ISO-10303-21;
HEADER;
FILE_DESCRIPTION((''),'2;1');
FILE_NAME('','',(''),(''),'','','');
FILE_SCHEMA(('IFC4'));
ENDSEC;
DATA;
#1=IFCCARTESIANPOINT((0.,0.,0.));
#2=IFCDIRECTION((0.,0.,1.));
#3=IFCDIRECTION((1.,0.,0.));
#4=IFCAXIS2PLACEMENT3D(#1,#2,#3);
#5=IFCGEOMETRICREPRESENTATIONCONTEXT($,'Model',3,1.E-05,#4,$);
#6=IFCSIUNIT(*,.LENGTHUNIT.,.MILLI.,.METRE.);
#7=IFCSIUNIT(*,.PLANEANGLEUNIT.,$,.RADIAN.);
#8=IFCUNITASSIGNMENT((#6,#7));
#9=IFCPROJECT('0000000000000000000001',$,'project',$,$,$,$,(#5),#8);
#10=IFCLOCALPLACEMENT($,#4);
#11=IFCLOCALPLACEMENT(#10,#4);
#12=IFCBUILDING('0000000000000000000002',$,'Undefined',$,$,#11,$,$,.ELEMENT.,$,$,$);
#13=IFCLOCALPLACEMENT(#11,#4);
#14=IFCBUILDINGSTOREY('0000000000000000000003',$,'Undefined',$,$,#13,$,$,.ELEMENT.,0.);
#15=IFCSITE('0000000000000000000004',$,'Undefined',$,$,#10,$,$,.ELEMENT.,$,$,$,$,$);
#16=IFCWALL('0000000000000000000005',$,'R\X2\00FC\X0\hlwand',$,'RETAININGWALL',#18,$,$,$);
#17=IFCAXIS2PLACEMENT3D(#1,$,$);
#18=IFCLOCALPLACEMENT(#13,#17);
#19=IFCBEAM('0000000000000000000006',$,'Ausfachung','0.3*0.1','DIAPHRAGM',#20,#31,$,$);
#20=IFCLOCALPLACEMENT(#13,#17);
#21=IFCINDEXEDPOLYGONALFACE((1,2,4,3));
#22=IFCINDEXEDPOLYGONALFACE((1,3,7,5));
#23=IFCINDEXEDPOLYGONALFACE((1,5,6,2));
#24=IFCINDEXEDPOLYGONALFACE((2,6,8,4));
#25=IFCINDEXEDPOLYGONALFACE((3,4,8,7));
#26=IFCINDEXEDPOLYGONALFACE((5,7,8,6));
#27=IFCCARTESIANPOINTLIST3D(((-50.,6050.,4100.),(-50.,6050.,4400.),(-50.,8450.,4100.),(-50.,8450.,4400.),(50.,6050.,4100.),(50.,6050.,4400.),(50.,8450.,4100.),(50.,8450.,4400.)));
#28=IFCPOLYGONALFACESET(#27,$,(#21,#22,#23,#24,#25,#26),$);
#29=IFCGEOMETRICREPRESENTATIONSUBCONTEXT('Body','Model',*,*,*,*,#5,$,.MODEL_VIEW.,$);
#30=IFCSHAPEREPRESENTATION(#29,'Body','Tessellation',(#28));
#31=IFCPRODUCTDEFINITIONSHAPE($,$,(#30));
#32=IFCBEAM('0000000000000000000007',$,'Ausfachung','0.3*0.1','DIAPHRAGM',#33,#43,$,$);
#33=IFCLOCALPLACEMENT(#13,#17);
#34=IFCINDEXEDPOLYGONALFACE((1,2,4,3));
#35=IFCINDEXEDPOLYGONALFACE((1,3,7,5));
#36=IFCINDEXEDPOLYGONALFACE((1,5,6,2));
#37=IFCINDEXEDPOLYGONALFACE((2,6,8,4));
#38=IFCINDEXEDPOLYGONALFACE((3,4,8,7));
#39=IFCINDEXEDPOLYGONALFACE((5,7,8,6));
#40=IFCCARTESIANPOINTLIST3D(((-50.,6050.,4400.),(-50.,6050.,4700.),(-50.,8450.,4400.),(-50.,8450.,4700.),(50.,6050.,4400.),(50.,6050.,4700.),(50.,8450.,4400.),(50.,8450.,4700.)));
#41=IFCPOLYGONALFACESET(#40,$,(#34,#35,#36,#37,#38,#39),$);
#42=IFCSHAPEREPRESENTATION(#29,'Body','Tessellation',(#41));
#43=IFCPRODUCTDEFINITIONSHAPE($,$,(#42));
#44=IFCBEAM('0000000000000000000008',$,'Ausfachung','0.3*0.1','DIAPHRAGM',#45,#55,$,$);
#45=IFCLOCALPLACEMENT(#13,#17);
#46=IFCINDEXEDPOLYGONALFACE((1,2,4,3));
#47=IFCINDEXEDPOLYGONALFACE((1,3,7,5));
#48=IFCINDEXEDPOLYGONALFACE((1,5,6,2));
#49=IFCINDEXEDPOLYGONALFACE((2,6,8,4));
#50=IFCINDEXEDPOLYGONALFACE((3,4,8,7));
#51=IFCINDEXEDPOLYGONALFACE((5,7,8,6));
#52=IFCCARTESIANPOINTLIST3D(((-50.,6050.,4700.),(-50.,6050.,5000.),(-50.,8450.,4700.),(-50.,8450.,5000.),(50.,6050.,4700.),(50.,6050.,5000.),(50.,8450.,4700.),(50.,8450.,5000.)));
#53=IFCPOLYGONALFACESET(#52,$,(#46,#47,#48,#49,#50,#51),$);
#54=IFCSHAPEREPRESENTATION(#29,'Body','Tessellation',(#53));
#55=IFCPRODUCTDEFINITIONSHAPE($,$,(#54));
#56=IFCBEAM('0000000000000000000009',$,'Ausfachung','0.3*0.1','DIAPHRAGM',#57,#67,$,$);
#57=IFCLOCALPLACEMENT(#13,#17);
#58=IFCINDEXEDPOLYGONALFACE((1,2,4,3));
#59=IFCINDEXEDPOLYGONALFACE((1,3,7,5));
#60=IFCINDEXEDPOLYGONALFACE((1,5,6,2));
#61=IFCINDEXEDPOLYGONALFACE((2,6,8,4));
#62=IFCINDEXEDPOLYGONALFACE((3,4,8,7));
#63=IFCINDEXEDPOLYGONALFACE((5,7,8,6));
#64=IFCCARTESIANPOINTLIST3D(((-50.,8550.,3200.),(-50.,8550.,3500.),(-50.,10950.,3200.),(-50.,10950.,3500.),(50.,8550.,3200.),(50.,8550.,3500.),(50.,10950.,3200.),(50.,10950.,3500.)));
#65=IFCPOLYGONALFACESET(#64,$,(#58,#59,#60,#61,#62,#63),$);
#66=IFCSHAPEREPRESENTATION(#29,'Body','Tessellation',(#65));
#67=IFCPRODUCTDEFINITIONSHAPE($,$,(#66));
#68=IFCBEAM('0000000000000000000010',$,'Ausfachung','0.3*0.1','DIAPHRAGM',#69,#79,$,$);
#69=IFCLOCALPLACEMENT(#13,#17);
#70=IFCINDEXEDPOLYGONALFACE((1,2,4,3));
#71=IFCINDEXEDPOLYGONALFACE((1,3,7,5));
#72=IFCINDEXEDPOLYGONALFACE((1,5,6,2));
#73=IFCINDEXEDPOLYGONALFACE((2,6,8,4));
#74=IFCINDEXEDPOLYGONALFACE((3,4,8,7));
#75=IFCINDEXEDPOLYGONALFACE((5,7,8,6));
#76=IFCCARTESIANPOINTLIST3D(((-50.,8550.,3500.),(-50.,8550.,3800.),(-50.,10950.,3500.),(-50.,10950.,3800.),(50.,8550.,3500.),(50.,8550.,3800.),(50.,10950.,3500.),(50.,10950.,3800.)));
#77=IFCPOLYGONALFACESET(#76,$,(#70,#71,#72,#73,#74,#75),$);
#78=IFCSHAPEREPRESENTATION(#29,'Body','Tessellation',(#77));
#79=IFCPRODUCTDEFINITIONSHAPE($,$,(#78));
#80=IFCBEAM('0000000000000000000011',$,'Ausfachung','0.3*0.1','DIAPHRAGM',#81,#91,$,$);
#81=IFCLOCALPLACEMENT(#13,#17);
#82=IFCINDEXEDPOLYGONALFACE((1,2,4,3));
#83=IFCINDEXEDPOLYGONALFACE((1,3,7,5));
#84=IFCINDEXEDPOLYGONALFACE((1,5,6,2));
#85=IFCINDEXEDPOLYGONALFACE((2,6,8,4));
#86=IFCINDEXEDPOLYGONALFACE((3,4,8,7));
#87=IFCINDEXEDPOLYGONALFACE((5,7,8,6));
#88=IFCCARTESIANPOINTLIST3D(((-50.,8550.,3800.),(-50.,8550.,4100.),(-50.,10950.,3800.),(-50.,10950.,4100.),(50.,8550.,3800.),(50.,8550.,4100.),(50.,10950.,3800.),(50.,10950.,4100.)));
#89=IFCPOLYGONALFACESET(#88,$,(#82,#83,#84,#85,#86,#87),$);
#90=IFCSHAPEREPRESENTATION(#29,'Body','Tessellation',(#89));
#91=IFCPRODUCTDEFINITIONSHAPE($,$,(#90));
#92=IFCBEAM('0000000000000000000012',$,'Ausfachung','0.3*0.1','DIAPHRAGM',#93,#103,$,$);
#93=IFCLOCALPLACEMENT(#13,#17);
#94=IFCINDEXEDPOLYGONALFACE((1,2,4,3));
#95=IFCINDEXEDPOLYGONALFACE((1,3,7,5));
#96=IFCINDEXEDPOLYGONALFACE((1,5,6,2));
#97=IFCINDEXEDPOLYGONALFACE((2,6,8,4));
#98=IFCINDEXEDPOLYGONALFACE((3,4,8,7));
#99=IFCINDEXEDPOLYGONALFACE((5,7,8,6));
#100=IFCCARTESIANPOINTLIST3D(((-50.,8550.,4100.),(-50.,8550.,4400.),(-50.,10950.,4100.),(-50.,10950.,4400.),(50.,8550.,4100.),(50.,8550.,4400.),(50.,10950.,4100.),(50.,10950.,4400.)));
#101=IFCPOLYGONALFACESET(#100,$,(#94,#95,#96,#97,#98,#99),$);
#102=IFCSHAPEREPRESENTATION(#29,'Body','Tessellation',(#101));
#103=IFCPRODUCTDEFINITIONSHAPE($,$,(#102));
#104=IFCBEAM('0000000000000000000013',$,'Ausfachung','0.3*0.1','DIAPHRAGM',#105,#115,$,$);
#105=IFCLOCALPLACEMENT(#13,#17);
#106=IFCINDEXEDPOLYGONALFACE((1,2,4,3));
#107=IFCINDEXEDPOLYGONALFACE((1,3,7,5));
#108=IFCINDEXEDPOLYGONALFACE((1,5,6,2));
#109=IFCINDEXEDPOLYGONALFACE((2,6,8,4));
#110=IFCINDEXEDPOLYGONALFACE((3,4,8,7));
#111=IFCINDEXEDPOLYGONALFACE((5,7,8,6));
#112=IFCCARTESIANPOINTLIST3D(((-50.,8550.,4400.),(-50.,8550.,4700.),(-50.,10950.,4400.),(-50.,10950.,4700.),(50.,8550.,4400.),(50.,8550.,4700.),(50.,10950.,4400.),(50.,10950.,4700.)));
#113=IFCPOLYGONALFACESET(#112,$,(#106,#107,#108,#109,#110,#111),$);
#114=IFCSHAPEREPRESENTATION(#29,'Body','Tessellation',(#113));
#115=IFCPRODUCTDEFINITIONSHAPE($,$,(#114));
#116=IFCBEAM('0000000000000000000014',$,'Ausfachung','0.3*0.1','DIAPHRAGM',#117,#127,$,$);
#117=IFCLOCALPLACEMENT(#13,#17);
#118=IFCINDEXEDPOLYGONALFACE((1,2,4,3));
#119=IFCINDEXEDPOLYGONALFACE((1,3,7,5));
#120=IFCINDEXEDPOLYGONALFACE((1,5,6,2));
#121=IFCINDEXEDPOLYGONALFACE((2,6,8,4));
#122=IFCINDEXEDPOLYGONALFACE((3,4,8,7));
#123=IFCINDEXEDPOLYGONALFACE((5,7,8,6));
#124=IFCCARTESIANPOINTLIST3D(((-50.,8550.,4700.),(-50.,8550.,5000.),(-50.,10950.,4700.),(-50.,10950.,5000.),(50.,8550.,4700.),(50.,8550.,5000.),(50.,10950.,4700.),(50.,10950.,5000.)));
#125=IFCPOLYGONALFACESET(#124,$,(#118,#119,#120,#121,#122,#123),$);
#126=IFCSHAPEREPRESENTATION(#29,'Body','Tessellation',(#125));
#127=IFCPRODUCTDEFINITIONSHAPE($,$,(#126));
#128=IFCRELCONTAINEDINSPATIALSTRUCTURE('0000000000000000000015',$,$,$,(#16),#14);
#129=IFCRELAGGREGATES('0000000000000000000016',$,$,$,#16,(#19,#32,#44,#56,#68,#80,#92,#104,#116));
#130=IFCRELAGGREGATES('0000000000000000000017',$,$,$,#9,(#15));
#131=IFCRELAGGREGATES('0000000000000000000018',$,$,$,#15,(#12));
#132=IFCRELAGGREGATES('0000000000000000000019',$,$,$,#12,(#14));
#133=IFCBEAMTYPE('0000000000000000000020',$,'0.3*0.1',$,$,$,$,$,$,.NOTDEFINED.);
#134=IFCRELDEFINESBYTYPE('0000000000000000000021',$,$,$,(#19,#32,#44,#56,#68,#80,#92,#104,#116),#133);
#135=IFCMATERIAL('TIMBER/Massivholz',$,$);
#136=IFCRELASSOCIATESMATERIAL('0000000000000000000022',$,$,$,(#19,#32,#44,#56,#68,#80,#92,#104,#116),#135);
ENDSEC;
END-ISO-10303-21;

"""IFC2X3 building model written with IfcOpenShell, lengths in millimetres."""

from ifc_helpers import new_model, si_unit, frame, origin_with_axes, origin_2d_with_axis, place, context, subcontext, project, spatial, rectangle, extrude, material, type_object, element, aggregate, save


model = new_model("IFC2X3")

# Units and contexts
model_context = context("Model", 3, precision=1e-05, world=origin_with_axes())
body_context = subcontext(model_context, "Body", "Model", "MODEL_VIEW")
ifc_project = project(units=[si_unit("LENGTHUNIT", "METRE", prefix="MILLI"), si_unit("PLANEANGLEUNIT", "RADIAN")], contexts=[model_context])

# Site, building, storey
site_placement = place(None, origin_with_axes())
site = spatial("IfcSite", under=ifc_project, at=site_placement, Name="Undefined", CompositionType="ELEMENT")
building_placement = place(site_placement, origin_with_axes())
building = spatial("IfcBuilding", under=site, at=building_placement, Name="Undefined", CompositionType="ELEMENT")
storey_placement = place(building_placement, origin_with_axes())
storey = spatial("IfcBuildingStorey", under=building, at=storey_placement, Name="Undefined", CompositionType="ELEMENT", Elevation=0.0)

# Wall, beams
wall_placement = place(storey_placement, origin_with_axes())
wall = element("IfcWall", 1, at=wall_placement, inside=storey, Name="Rühlwand", ObjectType="RETAININGWALL")
ifc_material_1 = material(Name="TIMBER/Massivholz")
beam_type = type_object("IfcBeamType", Name="0.3*0.1", PredefinedType="NOTDEFINED")
beam_1_placement = place(wall_placement, frame((0.0, 8450.0, 4250.0), z_axis=(0.0, 0.0, -1.0), x_axis=(0.0, -1.0, 0.0)))
beam_1 = element("IfcBeam", 2, at=beam_1_placement, type_object=beam_type, material=ifc_material_1, Name="Ausfachung", Description="0.3*0.1", ObjectType="DIAPHRAGM", context=body_context, shape_type="SweptSolid", body=[
    extrude(rectangle(XDim=100.0, YDim=300.0, at=origin_2d_with_axis()), frame((2400.0, 0.0, 0.0), z_axis=(-1.0, 0.0, 0.0), x_axis=(0.0, -1.0, 0.0)), (0.0, 0.0, 1.0), 2400.0),
])
beam_2_placement = place(wall_placement, frame((0.0, 8450.0, 4550.0), z_axis=(0.0, 0.0, -1.0), x_axis=(0.0, -1.0, 0.0)))
beam_2 = element("IfcBeam", 3, at=beam_2_placement, type_object=beam_type, material=ifc_material_1, Name="Ausfachung", Description="0.3*0.1", ObjectType="DIAPHRAGM", context=body_context, shape_type="SweptSolid", body=[
    extrude(rectangle(XDim=100.0, YDim=300.0, at=origin_2d_with_axis()), frame((2400.0, 0.0, 0.0), z_axis=(-1.0, 0.0, 0.0), x_axis=(0.0, -1.0, 0.0)), (0.0, 0.0, 1.0), 2400.0),
])
beam_3_placement = place(wall_placement, frame((0.0, 8450.0, 4850.0), z_axis=(0.0, 0.0, -1.0), x_axis=(0.0, -1.0, 0.0)))
beam_3 = element("IfcBeam", 4, at=beam_3_placement, type_object=beam_type, material=ifc_material_1, Name="Ausfachung", Description="0.3*0.1", ObjectType="DIAPHRAGM", context=body_context, shape_type="SweptSolid", body=[
    extrude(rectangle(XDim=100.0, YDim=300.0, at=origin_2d_with_axis()), frame((2400.0, 0.0, 0.0), z_axis=(-1.0, 0.0, 0.0), x_axis=(0.0, -1.0, 0.0)), (0.0, 0.0, 1.0), 2400.0),
])
beam_4_placement = place(wall_placement, frame((0.0, 10950.0, 3350.0), z_axis=(0.0, 0.0, -1.0), x_axis=(0.0, -1.0, 0.0)))
beam_4 = element("IfcBeam", 5, at=beam_4_placement, type_object=beam_type, material=ifc_material_1, Name="Ausfachung", Description="0.3*0.1", ObjectType="DIAPHRAGM", context=body_context, shape_type="SweptSolid", body=[
    extrude(rectangle(XDim=100.0, YDim=300.0, at=origin_2d_with_axis()), frame((2400.0, 0.0, 0.0), z_axis=(-1.0, 0.0, 0.0), x_axis=(0.0, -1.0, 0.0)), (0.0, 0.0, 1.0), 2400.0),
])
beam_5_placement = place(wall_placement, frame((0.0, 10950.0, 3650.0), z_axis=(0.0, 0.0, -1.0), x_axis=(0.0, -1.0, 0.0)))
beam_5 = element("IfcBeam", 6, at=beam_5_placement, type_object=beam_type, material=ifc_material_1, Name="Ausfachung", Description="0.3*0.1", ObjectType="DIAPHRAGM", context=body_context, shape_type="SweptSolid", body=[
    extrude(rectangle(XDim=100.0, YDim=300.0, at=origin_2d_with_axis()), frame((2400.0, 0.0, 0.0), z_axis=(-1.0, 0.0, 0.0), x_axis=(0.0, -1.0, 0.0)), (0.0, 0.0, 1.0), 2400.0),
])
beam_6_placement = place(wall_placement, frame((0.0, 10950.0, 3950.0), z_axis=(0.0, 0.0, -1.0), x_axis=(0.0, -1.0, 0.0)))
beam_6 = element("IfcBeam", 7, at=beam_6_placement, type_object=beam_type, material=ifc_material_1, Name="Ausfachung", Description="0.3*0.1", ObjectType="DIAPHRAGM", context=body_context, shape_type="SweptSolid", body=[
    extrude(rectangle(XDim=100.0, YDim=300.0, at=origin_2d_with_axis()), frame((2400.0, 0.0, 0.0), z_axis=(-1.0, 0.0, 0.0), x_axis=(0.0, -1.0, 0.0)), (0.0, 0.0, 1.0), 2400.0),
])
beam_7_placement = place(wall_placement, frame((0.0, 10950.0, 4250.0), z_axis=(0.0, 0.0, -1.0), x_axis=(0.0, -1.0, 0.0)))
beam_7 = element("IfcBeam", 8, at=beam_7_placement, type_object=beam_type, material=ifc_material_1, Name="Ausfachung", Description="0.3*0.1", ObjectType="DIAPHRAGM", context=body_context, shape_type="SweptSolid", body=[
    extrude(rectangle(XDim=100.0, YDim=300.0, at=origin_2d_with_axis()), frame((2400.0, 0.0, 0.0), z_axis=(-1.0, 0.0, 0.0), x_axis=(0.0, -1.0, 0.0)), (0.0, 0.0, 1.0), 2400.0),
])
beam_8_placement = place(wall_placement, frame((0.0, 10950.0, 4550.0), z_axis=(0.0, 0.0, -1.0), x_axis=(0.0, -1.0, 0.0)))
beam_8 = element("IfcBeam", 9, at=beam_8_placement, type_object=beam_type, material=ifc_material_1, Name="Ausfachung", Description="0.3*0.1", ObjectType="DIAPHRAGM", context=body_context, shape_type="SweptSolid", body=[
    extrude(rectangle(XDim=100.0, YDim=300.0, at=origin_2d_with_axis()), frame((2400.0, 0.0, 0.0), z_axis=(-1.0, 0.0, 0.0), x_axis=(0.0, -1.0, 0.0)), (0.0, 0.0, 1.0), 2400.0),
])
beam_9_placement = place(wall_placement, frame((0.0, 10950.0, 4850.0), z_axis=(0.0, 0.0, -1.0), x_axis=(0.0, -1.0, 0.0)))
beam_9 = element("IfcBeam", 10, at=beam_9_placement, type_object=beam_type, material=ifc_material_1, Name="Ausfachung", Description="0.3*0.1", ObjectType="DIAPHRAGM", context=body_context, shape_type="SweptSolid", body=[
    extrude(rectangle(XDim=100.0, YDim=300.0, at=origin_2d_with_axis()), frame((2400.0, 0.0, 0.0), z_axis=(-1.0, 0.0, 0.0), x_axis=(0.0, -1.0, 0.0)), (0.0, 0.0, 1.0), 2400.0),
])
aggregate(wall, [beam_1, beam_2, beam_3, beam_4, beam_5, beam_6, beam_7, beam_8, beam_9])

save(model, "model.ifc")
